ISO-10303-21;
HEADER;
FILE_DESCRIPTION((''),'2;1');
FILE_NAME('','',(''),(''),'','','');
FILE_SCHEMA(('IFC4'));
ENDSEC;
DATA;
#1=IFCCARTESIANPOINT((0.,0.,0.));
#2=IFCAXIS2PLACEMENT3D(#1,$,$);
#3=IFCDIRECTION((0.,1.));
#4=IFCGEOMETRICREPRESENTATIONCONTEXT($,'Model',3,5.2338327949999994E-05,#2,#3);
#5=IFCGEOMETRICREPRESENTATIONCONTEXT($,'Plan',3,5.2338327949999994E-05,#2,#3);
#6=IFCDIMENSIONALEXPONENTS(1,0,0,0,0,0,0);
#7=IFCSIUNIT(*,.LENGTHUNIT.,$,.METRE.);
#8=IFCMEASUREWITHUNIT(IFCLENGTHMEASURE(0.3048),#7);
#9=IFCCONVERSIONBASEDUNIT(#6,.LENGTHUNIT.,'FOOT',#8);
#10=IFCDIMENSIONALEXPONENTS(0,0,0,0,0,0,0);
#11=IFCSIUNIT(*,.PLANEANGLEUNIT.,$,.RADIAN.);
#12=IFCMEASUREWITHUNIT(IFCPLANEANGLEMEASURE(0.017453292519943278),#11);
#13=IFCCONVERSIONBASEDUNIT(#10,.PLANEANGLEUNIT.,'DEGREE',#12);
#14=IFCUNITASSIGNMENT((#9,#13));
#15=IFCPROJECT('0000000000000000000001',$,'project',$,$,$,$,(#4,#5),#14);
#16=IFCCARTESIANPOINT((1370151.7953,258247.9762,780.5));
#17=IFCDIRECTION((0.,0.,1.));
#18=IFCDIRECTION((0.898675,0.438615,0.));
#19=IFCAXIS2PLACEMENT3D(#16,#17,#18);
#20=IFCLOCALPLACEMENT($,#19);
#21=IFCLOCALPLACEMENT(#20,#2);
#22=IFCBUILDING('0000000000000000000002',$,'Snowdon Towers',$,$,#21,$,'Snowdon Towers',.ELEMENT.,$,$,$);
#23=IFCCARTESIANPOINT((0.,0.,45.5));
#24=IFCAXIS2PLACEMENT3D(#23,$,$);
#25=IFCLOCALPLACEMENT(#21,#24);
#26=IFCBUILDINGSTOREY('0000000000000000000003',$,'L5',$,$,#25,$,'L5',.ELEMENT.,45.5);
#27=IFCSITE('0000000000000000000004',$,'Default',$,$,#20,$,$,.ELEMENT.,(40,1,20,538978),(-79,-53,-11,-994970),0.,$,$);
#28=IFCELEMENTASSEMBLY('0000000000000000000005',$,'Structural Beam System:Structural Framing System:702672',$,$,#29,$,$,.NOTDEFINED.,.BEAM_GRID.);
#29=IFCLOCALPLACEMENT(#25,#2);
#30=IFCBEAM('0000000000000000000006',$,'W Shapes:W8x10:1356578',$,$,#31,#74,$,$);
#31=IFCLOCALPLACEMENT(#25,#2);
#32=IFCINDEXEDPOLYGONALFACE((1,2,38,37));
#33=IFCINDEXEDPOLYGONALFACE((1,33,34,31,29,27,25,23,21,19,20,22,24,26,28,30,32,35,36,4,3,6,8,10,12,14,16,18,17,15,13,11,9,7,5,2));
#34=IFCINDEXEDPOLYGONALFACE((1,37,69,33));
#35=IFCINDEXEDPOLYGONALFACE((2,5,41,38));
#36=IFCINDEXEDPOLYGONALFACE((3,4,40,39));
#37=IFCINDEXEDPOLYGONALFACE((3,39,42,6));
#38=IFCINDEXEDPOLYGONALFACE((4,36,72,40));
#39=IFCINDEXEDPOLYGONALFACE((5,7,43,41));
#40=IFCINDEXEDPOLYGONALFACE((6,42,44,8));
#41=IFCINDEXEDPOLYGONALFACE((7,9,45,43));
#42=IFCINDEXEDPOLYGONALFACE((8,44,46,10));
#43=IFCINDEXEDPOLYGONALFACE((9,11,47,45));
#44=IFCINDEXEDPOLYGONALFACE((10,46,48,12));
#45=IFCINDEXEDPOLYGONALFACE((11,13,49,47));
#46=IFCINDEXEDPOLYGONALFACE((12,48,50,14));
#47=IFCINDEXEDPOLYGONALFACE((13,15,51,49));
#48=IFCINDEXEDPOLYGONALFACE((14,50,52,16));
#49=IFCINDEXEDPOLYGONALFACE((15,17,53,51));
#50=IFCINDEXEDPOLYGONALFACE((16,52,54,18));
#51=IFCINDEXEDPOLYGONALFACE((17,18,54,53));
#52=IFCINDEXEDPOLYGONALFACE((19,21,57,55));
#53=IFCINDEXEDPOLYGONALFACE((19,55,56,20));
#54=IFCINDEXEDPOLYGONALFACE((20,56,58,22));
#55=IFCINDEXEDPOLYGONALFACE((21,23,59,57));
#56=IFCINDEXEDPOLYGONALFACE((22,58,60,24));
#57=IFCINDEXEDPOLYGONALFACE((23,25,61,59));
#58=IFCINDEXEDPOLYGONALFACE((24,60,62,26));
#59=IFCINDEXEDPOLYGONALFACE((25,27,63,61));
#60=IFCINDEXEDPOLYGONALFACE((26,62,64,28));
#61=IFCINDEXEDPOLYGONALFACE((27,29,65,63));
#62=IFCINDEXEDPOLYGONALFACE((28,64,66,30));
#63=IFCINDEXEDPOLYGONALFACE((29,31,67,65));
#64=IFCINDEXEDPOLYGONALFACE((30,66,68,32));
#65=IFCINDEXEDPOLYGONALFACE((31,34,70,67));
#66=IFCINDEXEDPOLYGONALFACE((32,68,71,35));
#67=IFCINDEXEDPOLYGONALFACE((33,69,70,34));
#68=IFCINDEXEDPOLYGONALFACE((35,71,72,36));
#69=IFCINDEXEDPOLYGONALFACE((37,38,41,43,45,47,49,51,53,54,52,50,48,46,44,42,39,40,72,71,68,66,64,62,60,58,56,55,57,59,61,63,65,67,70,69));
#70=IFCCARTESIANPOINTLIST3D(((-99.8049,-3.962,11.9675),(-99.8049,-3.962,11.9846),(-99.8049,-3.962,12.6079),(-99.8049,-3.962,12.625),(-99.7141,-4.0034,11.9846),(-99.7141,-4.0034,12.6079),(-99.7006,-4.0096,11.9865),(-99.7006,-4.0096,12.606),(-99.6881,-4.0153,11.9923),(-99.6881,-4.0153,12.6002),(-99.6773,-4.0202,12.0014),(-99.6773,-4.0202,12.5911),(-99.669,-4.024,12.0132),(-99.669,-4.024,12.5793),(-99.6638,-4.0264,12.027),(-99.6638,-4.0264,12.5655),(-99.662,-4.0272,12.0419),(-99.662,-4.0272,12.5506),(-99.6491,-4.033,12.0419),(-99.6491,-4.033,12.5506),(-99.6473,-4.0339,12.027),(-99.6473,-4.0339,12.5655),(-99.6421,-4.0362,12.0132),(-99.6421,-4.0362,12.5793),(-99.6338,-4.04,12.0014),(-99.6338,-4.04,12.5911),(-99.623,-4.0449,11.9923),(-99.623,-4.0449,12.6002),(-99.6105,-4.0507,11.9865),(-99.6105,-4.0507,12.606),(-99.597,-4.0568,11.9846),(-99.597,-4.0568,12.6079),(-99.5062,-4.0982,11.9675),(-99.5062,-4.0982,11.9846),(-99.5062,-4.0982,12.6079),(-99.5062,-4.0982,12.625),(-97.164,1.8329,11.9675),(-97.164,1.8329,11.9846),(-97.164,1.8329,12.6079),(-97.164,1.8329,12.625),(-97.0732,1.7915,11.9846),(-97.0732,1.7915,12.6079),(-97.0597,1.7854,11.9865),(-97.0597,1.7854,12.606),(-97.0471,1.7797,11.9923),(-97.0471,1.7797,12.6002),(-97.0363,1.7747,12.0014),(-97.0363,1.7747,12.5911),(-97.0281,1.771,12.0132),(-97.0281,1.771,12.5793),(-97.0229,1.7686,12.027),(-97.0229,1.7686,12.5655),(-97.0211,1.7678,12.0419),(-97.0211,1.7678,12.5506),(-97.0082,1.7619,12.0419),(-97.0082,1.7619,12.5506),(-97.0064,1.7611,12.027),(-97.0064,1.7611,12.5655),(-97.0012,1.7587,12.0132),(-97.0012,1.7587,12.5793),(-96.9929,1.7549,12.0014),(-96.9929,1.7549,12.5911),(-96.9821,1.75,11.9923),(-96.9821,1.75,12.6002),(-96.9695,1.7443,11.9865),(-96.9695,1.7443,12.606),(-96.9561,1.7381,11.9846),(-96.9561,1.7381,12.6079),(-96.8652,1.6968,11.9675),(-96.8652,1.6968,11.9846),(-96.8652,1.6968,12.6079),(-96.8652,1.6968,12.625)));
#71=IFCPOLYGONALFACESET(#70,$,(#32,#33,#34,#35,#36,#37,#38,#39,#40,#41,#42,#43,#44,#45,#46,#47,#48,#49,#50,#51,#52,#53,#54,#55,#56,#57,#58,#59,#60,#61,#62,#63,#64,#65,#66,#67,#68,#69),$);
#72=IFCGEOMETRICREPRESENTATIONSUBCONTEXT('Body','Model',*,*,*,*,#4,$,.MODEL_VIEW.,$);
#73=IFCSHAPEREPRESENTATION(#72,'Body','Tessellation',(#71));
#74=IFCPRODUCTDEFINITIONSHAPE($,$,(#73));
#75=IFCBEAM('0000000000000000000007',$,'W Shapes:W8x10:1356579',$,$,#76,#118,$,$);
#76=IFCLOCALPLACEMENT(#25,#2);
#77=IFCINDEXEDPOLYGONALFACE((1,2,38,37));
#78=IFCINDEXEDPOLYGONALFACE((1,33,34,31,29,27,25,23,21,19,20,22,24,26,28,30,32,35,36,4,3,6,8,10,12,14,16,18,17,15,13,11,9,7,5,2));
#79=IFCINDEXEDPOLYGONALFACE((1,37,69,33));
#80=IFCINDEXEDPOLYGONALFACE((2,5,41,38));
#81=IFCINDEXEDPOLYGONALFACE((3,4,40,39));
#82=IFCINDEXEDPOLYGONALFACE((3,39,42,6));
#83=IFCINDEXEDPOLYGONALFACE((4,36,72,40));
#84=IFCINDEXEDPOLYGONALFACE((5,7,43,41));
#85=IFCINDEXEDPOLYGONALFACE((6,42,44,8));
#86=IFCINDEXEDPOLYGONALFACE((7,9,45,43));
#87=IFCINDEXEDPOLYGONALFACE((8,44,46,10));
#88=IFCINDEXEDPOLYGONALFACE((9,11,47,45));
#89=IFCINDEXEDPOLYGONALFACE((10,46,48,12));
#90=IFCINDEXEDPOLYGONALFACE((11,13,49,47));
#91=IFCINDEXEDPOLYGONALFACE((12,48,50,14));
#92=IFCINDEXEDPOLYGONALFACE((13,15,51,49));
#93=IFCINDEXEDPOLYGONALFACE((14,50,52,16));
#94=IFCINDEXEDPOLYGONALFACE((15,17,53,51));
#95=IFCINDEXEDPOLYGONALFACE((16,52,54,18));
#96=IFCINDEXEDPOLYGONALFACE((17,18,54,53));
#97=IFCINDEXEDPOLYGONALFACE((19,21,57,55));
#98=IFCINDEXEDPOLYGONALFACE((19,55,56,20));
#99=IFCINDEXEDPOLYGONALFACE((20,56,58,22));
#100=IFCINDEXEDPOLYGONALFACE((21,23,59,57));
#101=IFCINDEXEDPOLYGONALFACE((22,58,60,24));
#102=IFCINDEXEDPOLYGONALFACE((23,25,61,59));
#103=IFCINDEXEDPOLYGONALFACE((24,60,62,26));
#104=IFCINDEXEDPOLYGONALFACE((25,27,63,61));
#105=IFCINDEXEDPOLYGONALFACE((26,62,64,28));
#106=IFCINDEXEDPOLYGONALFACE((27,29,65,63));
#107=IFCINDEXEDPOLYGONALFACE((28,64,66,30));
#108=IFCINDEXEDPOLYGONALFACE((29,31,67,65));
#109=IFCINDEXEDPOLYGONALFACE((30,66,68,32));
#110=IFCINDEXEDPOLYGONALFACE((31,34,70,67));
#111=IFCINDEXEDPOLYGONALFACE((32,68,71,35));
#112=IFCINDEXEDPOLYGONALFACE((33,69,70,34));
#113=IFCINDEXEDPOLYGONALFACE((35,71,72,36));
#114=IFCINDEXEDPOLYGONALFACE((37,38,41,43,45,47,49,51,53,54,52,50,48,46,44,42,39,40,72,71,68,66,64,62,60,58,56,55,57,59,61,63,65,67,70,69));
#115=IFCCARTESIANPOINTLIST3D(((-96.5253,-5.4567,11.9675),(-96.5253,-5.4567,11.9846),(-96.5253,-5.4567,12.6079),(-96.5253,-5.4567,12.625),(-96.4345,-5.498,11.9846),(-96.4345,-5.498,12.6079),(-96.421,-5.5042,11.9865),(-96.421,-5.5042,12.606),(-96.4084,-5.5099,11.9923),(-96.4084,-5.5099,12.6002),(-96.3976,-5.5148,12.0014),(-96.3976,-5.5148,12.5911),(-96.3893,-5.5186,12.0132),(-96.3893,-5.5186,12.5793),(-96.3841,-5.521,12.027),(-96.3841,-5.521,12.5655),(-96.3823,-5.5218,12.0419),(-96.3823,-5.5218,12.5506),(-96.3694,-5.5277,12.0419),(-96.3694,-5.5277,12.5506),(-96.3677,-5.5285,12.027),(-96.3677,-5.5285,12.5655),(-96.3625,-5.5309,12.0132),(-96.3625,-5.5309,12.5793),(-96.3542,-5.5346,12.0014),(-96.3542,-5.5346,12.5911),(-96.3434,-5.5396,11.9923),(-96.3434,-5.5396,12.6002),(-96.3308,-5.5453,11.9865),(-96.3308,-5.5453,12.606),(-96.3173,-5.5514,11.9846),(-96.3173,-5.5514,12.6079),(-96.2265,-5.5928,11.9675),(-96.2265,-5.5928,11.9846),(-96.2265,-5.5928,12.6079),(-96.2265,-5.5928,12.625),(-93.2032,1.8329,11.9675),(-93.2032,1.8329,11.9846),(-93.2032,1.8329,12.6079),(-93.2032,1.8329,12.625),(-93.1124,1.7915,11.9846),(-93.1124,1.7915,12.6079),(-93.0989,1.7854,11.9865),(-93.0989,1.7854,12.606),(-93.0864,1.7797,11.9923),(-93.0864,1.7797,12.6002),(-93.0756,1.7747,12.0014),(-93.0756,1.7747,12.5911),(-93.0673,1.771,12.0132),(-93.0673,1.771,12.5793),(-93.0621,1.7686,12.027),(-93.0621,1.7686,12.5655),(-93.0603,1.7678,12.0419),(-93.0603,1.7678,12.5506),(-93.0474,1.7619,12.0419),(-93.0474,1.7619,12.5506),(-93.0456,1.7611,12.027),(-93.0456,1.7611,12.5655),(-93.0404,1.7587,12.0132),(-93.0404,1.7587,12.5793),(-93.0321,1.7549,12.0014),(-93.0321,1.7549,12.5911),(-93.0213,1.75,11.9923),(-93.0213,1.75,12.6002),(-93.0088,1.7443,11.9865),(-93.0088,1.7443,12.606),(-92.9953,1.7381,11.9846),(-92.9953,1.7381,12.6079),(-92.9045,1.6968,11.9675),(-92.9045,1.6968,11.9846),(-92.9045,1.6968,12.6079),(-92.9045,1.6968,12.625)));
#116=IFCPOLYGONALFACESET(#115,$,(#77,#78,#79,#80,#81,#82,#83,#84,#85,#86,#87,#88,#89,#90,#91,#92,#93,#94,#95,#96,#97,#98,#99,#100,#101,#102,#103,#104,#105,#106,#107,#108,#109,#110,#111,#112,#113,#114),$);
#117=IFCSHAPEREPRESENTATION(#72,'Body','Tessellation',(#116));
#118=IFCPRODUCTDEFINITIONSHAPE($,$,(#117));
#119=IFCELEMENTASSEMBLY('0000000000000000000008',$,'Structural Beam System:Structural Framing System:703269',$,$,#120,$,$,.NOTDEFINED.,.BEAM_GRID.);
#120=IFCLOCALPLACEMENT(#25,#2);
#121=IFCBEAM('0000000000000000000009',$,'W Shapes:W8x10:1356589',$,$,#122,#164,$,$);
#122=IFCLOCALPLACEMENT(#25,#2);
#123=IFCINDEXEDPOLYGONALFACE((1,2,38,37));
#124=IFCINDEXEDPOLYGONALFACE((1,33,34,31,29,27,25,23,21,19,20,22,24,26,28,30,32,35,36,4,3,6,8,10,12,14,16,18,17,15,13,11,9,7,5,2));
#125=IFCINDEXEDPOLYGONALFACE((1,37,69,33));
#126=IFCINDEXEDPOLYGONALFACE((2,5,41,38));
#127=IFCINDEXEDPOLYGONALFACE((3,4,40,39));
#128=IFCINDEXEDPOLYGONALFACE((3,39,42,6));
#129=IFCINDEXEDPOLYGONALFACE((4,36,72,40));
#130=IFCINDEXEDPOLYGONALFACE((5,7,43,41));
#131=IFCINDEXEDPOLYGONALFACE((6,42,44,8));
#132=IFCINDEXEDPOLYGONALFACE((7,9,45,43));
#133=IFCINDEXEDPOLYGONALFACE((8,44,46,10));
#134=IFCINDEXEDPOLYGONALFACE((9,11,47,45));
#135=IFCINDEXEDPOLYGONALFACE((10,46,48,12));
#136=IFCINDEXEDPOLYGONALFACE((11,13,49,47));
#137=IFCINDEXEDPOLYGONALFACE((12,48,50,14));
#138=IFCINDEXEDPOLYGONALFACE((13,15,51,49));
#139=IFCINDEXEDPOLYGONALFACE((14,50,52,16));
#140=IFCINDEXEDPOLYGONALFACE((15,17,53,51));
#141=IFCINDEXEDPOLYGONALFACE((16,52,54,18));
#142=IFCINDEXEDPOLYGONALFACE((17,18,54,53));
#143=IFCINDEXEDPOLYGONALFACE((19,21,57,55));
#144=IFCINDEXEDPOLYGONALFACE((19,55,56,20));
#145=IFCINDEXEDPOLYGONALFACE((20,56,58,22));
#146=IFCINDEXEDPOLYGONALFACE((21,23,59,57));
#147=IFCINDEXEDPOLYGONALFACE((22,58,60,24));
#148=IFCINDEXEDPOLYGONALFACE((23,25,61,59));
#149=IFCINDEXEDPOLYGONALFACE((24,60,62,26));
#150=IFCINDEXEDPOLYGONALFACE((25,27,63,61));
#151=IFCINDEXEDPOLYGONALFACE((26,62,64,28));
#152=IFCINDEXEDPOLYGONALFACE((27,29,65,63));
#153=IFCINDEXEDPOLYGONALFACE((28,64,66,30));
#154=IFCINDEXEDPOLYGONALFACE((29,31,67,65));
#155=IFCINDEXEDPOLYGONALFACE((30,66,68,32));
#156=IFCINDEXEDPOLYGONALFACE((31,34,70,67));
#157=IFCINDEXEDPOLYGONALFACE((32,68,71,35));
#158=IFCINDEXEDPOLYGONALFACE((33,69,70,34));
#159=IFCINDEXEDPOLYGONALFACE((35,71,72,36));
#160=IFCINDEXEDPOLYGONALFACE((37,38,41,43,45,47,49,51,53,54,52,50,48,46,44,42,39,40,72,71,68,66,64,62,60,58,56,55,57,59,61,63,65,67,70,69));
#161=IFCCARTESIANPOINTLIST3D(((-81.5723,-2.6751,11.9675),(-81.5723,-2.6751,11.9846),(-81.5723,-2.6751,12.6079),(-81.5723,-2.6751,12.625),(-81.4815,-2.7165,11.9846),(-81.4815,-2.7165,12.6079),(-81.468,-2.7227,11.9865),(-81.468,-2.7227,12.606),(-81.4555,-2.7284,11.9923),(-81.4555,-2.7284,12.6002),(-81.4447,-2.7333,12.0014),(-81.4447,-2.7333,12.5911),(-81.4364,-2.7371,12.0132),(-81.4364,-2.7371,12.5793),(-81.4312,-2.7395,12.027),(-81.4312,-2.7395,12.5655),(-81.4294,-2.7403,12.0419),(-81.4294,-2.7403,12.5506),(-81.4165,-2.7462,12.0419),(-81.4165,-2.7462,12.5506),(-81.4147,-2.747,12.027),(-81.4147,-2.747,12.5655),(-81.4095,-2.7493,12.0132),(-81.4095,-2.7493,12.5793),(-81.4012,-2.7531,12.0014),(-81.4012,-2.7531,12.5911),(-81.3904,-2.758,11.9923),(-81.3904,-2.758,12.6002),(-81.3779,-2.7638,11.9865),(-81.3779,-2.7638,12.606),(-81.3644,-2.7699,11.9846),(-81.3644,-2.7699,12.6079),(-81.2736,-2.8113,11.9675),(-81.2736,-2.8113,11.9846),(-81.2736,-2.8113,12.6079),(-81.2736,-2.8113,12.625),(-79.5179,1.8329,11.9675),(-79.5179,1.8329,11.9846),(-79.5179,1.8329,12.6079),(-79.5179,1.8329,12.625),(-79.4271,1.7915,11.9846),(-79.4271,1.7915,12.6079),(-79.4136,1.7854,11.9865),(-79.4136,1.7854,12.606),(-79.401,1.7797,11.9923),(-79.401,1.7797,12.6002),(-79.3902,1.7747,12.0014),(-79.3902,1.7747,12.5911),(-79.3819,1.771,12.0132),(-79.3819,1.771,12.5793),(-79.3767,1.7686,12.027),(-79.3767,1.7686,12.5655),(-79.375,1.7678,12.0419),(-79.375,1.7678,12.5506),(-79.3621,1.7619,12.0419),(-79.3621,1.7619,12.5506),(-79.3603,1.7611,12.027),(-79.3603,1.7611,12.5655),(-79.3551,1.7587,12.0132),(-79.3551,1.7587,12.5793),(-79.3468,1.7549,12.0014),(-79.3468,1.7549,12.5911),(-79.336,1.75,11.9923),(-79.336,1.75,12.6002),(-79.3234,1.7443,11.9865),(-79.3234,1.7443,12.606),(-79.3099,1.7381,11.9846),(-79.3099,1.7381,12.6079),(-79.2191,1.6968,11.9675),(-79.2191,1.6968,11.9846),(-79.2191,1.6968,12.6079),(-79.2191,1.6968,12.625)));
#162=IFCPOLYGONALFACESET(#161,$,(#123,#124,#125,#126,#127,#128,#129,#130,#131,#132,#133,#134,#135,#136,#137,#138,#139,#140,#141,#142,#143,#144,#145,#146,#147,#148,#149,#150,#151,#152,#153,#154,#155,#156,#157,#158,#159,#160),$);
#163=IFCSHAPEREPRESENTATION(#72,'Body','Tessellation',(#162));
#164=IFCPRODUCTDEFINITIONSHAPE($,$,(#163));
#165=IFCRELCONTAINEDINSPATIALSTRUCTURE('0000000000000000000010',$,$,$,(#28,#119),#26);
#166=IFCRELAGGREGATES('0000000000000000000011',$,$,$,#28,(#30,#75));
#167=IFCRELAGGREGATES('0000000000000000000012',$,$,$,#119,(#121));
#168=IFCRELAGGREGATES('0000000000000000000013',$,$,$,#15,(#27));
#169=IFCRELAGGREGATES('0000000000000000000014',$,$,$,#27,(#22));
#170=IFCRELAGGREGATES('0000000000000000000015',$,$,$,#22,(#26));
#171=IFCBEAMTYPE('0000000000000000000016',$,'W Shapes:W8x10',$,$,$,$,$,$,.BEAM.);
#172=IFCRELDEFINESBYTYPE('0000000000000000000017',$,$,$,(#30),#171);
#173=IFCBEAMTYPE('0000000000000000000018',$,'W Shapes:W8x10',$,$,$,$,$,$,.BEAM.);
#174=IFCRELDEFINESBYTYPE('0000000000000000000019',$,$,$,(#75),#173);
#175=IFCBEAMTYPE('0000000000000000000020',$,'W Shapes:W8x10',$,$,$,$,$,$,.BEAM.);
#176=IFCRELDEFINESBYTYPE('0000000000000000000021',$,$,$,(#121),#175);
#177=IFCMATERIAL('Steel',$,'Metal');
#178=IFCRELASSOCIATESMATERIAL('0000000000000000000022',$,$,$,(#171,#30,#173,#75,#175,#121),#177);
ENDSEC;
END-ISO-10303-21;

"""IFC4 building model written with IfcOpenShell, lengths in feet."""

from ifc_helpers import new_model, entity, si_unit, converted_unit, direction, frame, origin, place, context, subcontext, project, spatial, line, arc, indexed_curve, outline, extrude, source, transform, mapped, material, type_object, type_shapes, element, aggregate, save


model = new_model("IFC4")

# Units and contexts
model_context = context("Model", 3, precision=5.2338327949999994e-05, world=origin(), true_north=direction((0.0, 1.0)))
plan_context = context("Plan", 3, precision=5.2338327949999994e-05, world=origin(), true_north=direction((0.0, 1.0)))
body_context = subcontext(model_context, "Body", "Model", "MODEL_VIEW")
ifc_project = project(units=[converted_unit("LENGTHUNIT", "FOOT", entity("IfcLengthMeasure", 0.3048), si_unit("LENGTHUNIT", "METRE"), dimensions=[1, 0, 0, 0, 0, 0, 0]), converted_unit("PLANEANGLEUNIT", "DEGREE", entity("IfcPlaneAngleMeasure", 0.017453292519943278), si_unit("PLANEANGLEUNIT", "RADIAN"), dimensions=[0, 0, 0, 0, 0, 0, 0])], contexts=[model_context, plan_context])

# Site, building, storey
site_placement = place(None, frame((1370151.7953, 258247.9762, 780.5), z_axis=(0.0, 0.0, 1.0), x_axis=(0.898675, 0.438615, 0.0)))
site = spatial("IfcSite", under=ifc_project, at=site_placement, Name="Default", CompositionType="ELEMENT", RefLatitude=(40, 1, 20, 538978), RefLongitude=(-79, -53, -11, -994970), RefElevation=0.0)
building_placement = place(site_placement, origin())
building = spatial("IfcBuilding", under=site, at=building_placement, Name="Snowdon Towers", LongName="Snowdon Towers", CompositionType="ELEMENT")
storey_placement = place(building_placement, frame((0.0, 0.0, 45.5)))
storey = spatial("IfcBuildingStorey", under=building, at=storey_placement, Name="L5", LongName="L5", CompositionType="ELEMENT", Elevation=45.5)

# Shared definitions
ifc_material_1 = material(Name="Steel", Category="Metal")

# Element assemblies, beams
assembly_1_placement = place(storey_placement, origin())
assembly_1 = element("IfcElementAssembly", 1, at=assembly_1_placement, inside=storey, Name="Structural Beam System:Structural Framing System:702672", AssemblyPlace="NOTDEFINED", PredefinedType="BEAM_GRID")
beam_type_1 = type_object("IfcBeamType", Name="W Shapes:W8x10", PredefinedType="BEAM", material=ifc_material_1)
shared_shape_1 = source(origin(), body_context, "Body", "SweptSolid", [
    extrude(outline(indexed_curve([(-0.3287, -0.1642), (-0.3117, -0.1642), (-0.3117, -0.0644), (-0.2949, -0.0239), (-0.2544, -0.0071), (0.2544, -0.0071), (0.2949, -0.0239), (0.3117, -0.0644), (0.3117, -0.1642), (0.3288, -0.1642), (0.3288, 0.1642), (0.3117, 0.1642), (0.3117, 0.0644), (0.2949, 0.0239), (0.2544, 0.0071), (-0.2544, 0.0071), (-0.2949, 0.0239), (-0.3117, 0.0644), (-0.3117, 0.1642), (-0.3287, 0.1642)], segments=[line(1, 2, 3), arc(3, 4, 5), line(5, 6), arc(6, 7, 8), line(8, 9, 10, 11, 12, 13), arc(13, 14, 15), line(15, 16), arc(16, 17, 18), line(18, 19, 20, 1)], self_intersect=False)), frame((-3.4321, 0.0, 0.0), z_axis=(1.0, 0.0, 0.0), x_axis=(0.0, 0.0, -1.0)), (0.0, 0.0, 1.0), 6.3683),
])
type_shapes(beam_type_1, [shared_shape_1])
beam_1_placement = place(assembly_1_placement, frame((-98.2323, -0.907, 12.2963), z_axis=(0.0, 0.0, 1.0), x_axis=(0.414693, 0.909961, 0.0)))
beam_1 = element("IfcBeam", 2, at=beam_1_placement, type_object=beam_type_1, material=ifc_material_1, Name="W Shapes:W8x10:1356578", context=body_context, shape_type="MappedRepresentation", body=[
    mapped(shared_shape_1, transform((0.0, 0.0, 0.0), scale=1.0)),
])
beam_type_2 = type_object("IfcBeamType", Name="W Shapes:W8x10", PredefinedType="BEAM", material=ifc_material_1)
shared_shape_2 = source(origin(), body_context, "Body", "SweptSolid", [
    extrude(outline(indexed_curve([(-0.3287, -0.1642), (-0.3117, -0.1642), (-0.3117, -0.0644), (-0.2949, -0.0239), (-0.2544, -0.0071), (0.2544, -0.0071), (0.2949, -0.0239), (0.3117, -0.0644), (0.3117, -0.1642), (0.3288, -0.1642), (0.3288, 0.1642), (0.3117, 0.1642), (0.3117, 0.0644), (0.2949, 0.0239), (0.2544, 0.0071), (-0.2544, 0.0071), (-0.2949, 0.0239), (-0.3117, 0.0644), (-0.3117, 0.1642), (-0.3287, 0.1642)], segments=[line(1, 2, 3), arc(3, 4, 5), line(5, 6), arc(6, 7, 8), line(8, 9, 10, 11, 12, 13), arc(13, 14, 15), line(15, 16), arc(16, 17, 18), line(18, 19, 20, 1)], self_intersect=False)), frame((-4.2533, 0.0, 0.0), z_axis=(1.0, 0.0, 0.0), x_axis=(0.0, 0.0, -1.0)), (0.0, 0.0, 1.0), 8.0109),
])
type_shapes(beam_type_2, [shared_shape_2])
beam_2_placement = place(assembly_1_placement, frame((-94.6121, -1.6544, 12.2963), z_axis=(0.0, 0.0, 1.0), x_axis=(0.414693, 0.909961, 0.0)))
beam_2 = element("IfcBeam", 3, at=beam_2_placement, type_object=beam_type_2, material=ifc_material_1, Name="W Shapes:W8x10:1356579", context=body_context, shape_type="MappedRepresentation", body=[
    mapped(shared_shape_2, transform((0.0, 0.0, 0.0), scale=1.0)),
])
aggregate(assembly_1, [beam_1, beam_2])
assembly_2_placement = place(storey_placement, origin())
assembly_2 = element("IfcElementAssembly", 4, at=assembly_2_placement, inside=storey, Name="Structural Beam System:Structural Framing System:703269", AssemblyPlace="NOTDEFINED", PredefinedType="BEAM_GRID")
beam_type_3 = type_object("IfcBeamType", Name="W Shapes:W8x10", PredefinedType="BEAM", material=ifc_material_1)
shared_shape_3 = source(origin(), body_context, "Body", "SweptSolid", [
    extrude(outline(indexed_curve([(-0.3287, -0.1642), (-0.3117, -0.1642), (-0.3117, -0.0644), (-0.2949, -0.0239), (-0.2544, -0.0071), (0.2544, -0.0071), (0.2949, -0.0239), (0.3117, -0.0644), (0.3117, -0.1642), (0.3288, -0.1642), (0.3288, 0.1642), (0.3117, 0.1642), (0.3117, 0.0644), (0.2949, 0.0239), (0.2544, 0.0071), (-0.2544, 0.0071), (-0.2949, 0.0239), (-0.3117, 0.0644), (-0.3117, 0.1642), (-0.3287, 0.1642)], segments=[line(1, 2, 3), arc(3, 4, 5), line(5, 6), arc(6, 7, 8), line(8, 9, 10, 11, 12, 13), arc(13, 14, 15), line(15, 16), arc(16, 17, 18), line(18, 19, 20, 1)], self_intersect=False)), frame((-2.725, 0.0, 0.0), z_axis=(1.0, 0.0, 0.0), x_axis=(0.0, 0.0, -1.0)), (0.0, 0.0, 1.0), 4.9541),
])
type_shapes(beam_type_3, [shared_shape_3])
beam_3_placement = place(assembly_2_placement, frame((-80.2929, -0.2636, 12.2963), z_axis=(0.0, 0.0, 1.0), x_axis=(0.414693, 0.909961, 0.0)))
beam_3 = element("IfcBeam", 5, at=beam_3_placement, type_object=beam_type_3, material=ifc_material_1, Name="W Shapes:W8x10:1356589", context=body_context, shape_type="MappedRepresentation", body=[
    mapped(shared_shape_3, transform((0.0, 0.0, 0.0), scale=1.0)),
])
aggregate(assembly_2, [beam_3])

save(model, "model.ifc")
